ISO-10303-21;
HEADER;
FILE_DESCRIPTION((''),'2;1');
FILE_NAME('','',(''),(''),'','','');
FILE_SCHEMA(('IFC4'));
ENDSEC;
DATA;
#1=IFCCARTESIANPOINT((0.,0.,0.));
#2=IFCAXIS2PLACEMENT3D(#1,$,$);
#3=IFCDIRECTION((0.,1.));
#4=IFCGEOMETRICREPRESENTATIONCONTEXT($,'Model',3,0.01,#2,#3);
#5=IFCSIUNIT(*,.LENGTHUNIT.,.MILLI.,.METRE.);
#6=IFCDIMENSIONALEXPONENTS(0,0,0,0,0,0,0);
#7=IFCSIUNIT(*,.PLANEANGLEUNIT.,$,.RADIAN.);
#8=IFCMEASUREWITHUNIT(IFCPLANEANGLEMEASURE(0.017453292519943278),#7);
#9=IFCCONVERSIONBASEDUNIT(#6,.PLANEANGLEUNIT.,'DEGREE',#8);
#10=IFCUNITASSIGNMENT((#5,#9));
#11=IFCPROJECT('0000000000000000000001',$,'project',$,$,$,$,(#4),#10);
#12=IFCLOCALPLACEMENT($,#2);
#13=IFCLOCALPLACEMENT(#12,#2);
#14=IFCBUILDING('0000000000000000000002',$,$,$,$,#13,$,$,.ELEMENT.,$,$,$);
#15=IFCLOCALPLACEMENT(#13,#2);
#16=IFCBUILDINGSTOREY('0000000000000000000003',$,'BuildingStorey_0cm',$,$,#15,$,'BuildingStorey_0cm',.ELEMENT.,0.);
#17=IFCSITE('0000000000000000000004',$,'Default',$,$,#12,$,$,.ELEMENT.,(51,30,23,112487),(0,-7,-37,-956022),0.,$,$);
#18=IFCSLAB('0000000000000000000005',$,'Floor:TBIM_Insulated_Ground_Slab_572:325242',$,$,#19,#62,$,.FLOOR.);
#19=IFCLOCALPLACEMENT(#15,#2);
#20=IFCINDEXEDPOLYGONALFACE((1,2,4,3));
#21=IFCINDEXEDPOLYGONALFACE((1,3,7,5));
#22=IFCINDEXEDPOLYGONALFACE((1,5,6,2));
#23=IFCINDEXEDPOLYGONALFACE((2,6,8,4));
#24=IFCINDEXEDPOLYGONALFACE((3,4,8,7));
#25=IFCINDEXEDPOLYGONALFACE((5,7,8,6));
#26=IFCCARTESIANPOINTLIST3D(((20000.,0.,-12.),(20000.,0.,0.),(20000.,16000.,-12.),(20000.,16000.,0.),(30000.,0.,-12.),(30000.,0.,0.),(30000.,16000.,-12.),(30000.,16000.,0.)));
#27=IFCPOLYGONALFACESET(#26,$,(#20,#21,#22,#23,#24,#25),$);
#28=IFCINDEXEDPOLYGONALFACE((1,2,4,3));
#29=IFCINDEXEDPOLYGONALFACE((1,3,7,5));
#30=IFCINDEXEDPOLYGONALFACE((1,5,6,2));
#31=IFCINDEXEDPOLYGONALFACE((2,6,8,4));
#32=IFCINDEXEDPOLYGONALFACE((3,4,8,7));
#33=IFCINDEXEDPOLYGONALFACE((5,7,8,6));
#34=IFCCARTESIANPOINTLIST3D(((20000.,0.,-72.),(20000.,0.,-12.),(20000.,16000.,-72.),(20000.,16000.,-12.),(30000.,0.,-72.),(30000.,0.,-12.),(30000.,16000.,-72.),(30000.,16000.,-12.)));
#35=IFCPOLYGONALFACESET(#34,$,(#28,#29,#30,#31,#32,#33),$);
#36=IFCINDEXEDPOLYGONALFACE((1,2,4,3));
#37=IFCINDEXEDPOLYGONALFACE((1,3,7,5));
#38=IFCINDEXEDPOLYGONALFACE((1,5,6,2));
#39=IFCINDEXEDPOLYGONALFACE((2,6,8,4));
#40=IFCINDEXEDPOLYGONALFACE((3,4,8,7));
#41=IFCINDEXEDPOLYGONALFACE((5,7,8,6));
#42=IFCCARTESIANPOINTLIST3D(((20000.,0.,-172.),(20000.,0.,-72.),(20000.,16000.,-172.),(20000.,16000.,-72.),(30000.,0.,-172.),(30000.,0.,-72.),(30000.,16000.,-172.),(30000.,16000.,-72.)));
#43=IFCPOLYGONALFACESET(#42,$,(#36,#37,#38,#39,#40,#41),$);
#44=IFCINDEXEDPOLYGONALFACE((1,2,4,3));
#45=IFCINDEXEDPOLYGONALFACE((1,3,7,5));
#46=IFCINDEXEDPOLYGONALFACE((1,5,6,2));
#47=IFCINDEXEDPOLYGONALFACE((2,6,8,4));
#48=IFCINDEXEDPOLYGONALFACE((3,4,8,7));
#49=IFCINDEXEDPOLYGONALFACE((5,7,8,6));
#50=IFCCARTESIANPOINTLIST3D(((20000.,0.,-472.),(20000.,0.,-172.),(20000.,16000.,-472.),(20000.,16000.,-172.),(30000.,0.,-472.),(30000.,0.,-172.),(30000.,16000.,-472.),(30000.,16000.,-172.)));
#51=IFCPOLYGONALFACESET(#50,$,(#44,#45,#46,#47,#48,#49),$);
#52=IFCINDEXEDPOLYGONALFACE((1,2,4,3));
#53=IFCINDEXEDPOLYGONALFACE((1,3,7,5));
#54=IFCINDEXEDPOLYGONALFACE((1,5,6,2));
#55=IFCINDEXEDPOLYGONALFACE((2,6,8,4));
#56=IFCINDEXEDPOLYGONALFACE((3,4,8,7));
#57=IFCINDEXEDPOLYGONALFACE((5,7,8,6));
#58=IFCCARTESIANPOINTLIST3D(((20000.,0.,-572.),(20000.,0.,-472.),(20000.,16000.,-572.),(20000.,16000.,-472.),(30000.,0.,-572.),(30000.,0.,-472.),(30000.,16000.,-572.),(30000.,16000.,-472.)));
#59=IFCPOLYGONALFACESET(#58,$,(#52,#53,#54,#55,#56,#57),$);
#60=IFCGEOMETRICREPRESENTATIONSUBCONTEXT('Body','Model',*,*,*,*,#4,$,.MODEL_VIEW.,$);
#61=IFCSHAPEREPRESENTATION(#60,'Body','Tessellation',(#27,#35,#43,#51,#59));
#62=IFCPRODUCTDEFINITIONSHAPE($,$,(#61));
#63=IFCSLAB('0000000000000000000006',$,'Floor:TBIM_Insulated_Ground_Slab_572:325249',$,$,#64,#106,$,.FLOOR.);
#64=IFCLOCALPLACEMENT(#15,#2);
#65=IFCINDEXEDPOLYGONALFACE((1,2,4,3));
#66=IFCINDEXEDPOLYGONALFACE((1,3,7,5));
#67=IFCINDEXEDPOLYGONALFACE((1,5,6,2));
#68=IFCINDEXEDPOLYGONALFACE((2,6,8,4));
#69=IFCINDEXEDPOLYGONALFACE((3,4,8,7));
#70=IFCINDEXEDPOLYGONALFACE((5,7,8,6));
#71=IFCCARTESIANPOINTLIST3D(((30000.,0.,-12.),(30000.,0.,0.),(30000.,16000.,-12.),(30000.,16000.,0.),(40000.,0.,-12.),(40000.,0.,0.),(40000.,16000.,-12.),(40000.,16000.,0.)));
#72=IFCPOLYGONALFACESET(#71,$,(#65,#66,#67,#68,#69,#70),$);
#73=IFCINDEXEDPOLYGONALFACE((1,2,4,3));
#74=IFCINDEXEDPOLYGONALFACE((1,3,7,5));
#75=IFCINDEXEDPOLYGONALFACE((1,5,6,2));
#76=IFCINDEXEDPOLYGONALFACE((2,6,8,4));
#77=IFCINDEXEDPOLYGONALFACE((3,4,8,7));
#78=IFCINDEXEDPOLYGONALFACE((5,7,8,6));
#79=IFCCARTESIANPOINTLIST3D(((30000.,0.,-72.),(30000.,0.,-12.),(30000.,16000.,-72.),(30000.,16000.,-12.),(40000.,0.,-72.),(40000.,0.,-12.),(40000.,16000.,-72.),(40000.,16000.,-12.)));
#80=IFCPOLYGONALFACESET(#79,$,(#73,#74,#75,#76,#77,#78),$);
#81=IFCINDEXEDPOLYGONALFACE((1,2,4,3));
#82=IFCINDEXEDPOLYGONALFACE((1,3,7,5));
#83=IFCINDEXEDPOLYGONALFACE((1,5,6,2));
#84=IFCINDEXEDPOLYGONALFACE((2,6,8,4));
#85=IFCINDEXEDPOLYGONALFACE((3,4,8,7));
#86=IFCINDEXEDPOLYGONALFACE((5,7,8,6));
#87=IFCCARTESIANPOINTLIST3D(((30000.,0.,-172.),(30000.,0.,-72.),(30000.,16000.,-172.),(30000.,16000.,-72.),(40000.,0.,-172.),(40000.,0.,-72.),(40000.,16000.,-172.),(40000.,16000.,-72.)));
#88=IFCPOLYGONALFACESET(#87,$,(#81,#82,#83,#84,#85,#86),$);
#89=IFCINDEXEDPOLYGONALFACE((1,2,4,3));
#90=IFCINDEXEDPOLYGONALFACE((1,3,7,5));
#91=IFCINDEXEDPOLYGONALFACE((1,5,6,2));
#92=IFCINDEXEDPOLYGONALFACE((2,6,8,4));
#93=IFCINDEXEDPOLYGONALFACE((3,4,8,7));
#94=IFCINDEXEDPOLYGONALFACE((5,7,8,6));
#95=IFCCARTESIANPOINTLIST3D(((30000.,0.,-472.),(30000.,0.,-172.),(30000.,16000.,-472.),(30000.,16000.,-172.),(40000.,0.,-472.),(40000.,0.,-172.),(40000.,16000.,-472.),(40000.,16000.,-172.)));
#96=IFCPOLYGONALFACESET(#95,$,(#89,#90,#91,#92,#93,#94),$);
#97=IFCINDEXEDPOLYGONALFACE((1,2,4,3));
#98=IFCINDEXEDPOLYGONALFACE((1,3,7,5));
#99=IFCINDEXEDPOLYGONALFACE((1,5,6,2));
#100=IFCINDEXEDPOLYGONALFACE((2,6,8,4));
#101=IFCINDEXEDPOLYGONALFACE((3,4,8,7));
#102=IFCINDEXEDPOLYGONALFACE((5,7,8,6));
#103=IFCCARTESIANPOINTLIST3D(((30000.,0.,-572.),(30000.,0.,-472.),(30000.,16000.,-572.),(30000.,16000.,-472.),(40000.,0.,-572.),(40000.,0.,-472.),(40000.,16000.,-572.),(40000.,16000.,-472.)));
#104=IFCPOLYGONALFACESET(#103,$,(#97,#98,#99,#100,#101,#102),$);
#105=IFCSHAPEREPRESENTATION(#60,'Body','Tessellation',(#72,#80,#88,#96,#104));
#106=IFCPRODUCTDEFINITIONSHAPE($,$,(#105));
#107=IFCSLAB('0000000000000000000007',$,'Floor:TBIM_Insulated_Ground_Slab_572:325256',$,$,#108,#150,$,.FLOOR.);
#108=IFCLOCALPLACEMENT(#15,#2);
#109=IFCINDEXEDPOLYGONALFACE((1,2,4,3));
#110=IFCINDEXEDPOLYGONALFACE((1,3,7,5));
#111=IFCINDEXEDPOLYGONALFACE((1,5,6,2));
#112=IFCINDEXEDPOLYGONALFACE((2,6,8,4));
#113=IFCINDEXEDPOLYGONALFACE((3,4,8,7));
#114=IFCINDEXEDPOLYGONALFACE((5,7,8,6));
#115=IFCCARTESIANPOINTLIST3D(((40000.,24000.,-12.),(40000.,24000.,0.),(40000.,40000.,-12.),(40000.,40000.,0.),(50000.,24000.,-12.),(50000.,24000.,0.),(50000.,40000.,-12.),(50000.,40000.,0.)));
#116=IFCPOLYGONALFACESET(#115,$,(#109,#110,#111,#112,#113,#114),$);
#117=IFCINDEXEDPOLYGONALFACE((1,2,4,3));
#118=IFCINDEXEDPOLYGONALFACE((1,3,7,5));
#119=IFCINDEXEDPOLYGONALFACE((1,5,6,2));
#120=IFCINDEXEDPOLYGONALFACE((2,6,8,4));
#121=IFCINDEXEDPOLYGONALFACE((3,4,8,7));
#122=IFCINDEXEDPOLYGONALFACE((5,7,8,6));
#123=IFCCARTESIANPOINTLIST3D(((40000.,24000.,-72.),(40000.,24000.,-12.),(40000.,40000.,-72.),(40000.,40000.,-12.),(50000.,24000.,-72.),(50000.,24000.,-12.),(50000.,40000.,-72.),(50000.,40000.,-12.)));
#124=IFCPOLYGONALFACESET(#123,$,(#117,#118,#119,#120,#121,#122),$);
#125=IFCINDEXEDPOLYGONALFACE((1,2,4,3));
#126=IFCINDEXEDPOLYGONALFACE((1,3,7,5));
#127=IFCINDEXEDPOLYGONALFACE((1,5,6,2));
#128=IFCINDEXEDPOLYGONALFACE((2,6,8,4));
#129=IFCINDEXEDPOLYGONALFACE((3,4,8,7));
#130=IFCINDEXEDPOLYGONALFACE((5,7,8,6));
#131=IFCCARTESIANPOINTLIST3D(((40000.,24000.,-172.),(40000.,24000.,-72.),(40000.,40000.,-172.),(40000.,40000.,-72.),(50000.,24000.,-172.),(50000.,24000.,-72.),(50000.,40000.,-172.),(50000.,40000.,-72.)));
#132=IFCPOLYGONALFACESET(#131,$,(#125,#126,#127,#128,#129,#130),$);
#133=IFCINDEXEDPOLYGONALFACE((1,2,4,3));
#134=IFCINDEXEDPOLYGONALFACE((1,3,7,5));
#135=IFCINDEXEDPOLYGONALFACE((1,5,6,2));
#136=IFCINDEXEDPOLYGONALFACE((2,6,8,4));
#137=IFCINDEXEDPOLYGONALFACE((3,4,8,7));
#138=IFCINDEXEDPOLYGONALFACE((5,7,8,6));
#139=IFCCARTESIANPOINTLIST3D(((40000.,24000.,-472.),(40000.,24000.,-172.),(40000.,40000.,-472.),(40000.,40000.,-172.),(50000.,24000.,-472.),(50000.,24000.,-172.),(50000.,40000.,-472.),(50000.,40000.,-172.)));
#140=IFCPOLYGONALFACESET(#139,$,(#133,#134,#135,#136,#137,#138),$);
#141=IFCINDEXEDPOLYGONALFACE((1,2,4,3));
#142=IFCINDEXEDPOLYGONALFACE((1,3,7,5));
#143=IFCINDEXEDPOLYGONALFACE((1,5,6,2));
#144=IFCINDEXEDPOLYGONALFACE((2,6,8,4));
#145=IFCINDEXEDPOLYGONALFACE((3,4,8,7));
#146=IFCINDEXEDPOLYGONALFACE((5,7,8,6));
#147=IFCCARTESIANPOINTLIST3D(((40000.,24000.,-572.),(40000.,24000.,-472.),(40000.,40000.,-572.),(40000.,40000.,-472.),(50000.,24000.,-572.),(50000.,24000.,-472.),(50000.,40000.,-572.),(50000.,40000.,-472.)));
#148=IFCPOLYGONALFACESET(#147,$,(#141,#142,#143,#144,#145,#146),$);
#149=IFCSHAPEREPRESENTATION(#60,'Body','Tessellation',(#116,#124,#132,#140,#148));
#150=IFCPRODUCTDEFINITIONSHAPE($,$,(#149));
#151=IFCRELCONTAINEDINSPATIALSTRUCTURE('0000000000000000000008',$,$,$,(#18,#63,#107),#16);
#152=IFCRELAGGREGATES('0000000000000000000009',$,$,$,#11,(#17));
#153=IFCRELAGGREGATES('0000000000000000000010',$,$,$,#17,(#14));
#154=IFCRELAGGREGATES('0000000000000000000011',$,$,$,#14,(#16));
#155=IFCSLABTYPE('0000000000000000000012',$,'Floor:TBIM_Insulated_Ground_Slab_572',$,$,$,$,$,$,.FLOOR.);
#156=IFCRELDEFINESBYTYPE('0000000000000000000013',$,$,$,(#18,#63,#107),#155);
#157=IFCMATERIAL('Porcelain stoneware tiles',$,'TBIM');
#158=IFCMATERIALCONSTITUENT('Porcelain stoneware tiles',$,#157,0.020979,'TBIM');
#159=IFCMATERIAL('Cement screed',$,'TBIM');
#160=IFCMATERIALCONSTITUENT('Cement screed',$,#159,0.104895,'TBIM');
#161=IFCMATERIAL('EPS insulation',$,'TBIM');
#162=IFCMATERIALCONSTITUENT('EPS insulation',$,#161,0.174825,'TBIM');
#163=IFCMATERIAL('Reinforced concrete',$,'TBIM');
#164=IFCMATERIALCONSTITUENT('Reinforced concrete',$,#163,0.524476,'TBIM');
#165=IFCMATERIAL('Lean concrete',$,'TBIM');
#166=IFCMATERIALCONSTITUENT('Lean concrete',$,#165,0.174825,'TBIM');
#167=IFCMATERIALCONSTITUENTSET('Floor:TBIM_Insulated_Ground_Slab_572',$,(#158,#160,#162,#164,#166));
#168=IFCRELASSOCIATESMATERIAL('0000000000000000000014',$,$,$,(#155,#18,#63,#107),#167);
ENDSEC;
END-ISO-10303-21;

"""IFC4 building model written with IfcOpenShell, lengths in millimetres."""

from ifc_helpers import new_model, entity, si_unit, converted_unit, direction, frame, origin, place, context, subcontext, project, spatial, indexed_curve, outline, extrude, material, constituent, constituent_set, type_object, element, save


model = new_model("IFC4")

# Units and contexts
model_context = context("Model", 3, precision=0.01, world=origin(), true_north=direction((0.0, 1.0)))
body_context = subcontext(model_context, "Body", "Model", "MODEL_VIEW")
ifc_project = project(units=[si_unit("LENGTHUNIT", "METRE", prefix="MILLI"), converted_unit("PLANEANGLEUNIT", "DEGREE", entity("IfcPlaneAngleMeasure", 0.017453292519943278), si_unit("PLANEANGLEUNIT", "RADIAN"), dimensions=[0, 0, 0, 0, 0, 0, 0])], contexts=[model_context])

# Site, building, storey
site_placement = place(None, origin())
site = spatial("IfcSite", under=ifc_project, at=site_placement, Name="Default", CompositionType="ELEMENT", RefLatitude=(51, 30, 23, 112487), RefLongitude=(0, -7, -37, -956022), RefElevation=0.0)
building_placement = place(site_placement, origin())
building = spatial("IfcBuilding", under=site, at=building_placement, CompositionType="ELEMENT")
storey_placement = place(building_placement, origin())
storey = spatial("IfcBuildingStorey", under=building, at=storey_placement, Name="BuildingStorey_0cm", LongName="BuildingStorey_0cm", CompositionType="ELEMENT", Elevation=0.0)

# Slabs
ifc_material_1 = material(Name="Porcelain stoneware tiles", Category="TBIM")
ifc_constituent_1 = constituent(ifc_material_1, Name="Porcelain stoneware tiles", Category="TBIM", fraction=0.020979)
ifc_material_2 = material(Name="Cement screed", Category="TBIM")
ifc_constituent_2 = constituent(ifc_material_2, Name="Cement screed", Category="TBIM", fraction=0.104895)
ifc_material_3 = material(Name="EPS insulation", Category="TBIM")
ifc_constituent_3 = constituent(ifc_material_3, Name="EPS insulation", Category="TBIM", fraction=0.174825)
ifc_material_4 = material(Name="Reinforced concrete", Category="TBIM")
ifc_constituent_4 = constituent(ifc_material_4, Name="Reinforced concrete", Category="TBIM", fraction=0.524476)
ifc_material_5 = material(Name="Lean concrete", Category="TBIM")
ifc_constituent_5 = constituent(ifc_material_5, Name="Lean concrete", Category="TBIM", fraction=0.174825)
ifc_constituent_set_1 = constituent_set(constituents=[ifc_constituent_1, ifc_constituent_2, ifc_constituent_3, ifc_constituent_4, ifc_constituent_5], Name="Floor:TBIM_Insulated_Ground_Slab_572")
slab_type = type_object("IfcSlabType", Name="Floor:TBIM_Insulated_Ground_Slab_572", PredefinedType="FLOOR", material=ifc_constituent_set_1)
slab_1_placement = place(storey_placement, origin())
element("IfcSlab", 1, at=slab_1_placement, inside=storey, type_object=slab_type, material=ifc_constituent_set_1, Name="Floor:TBIM_Insulated_Ground_Slab_572:325242", PredefinedType="FLOOR", context=body_context, shape_type="SweptSolid", body=[
    extrude(outline(indexed_curve([(-5000.0, -8000.0), (5000.0, -8000.0), (5000.0, 8000.0), (-5000.0, 8000.0), (-5000.0, -8000.0)], self_intersect=False)), frame((25000.0, 8000.0, -12.0), z_axis=(0.0, 0.0, 1.0), x_axis=(-1.0, 0.0, 0.0)), (0.0, 0.0, 1.0), 12.0),
    extrude(outline(indexed_curve([(-5000.0, -8000.0), (5000.0, -8000.0), (5000.0, 8000.0), (-5000.0, 8000.0), (-5000.0, -8000.0)], self_intersect=False)), frame((25000.0, 8000.0, -72.0), z_axis=(0.0, 0.0, 1.0), x_axis=(-1.0, 0.0, 0.0)), (0.0, 0.0, 1.0), 60.0),
    extrude(outline(indexed_curve([(-5000.0, -8000.0), (5000.0, -8000.0), (5000.0, 8000.0), (-5000.0, 8000.0), (-5000.0, -8000.0)], self_intersect=False)), frame((25000.0, 8000.0, -172.0), z_axis=(0.0, 0.0, 1.0), x_axis=(-1.0, 0.0, 0.0)), (0.0, 0.0, 1.0), 100.0),
    extrude(outline(indexed_curve([(-5000.0, -8000.0), (5000.0, -8000.0), (5000.0, 8000.0), (-5000.0, 8000.0), (-5000.0, -8000.0)], self_intersect=False)), frame((25000.0, 8000.0, -472.0), z_axis=(0.0, 0.0, 1.0), x_axis=(-1.0, 0.0, 0.0)), (0.0, 0.0, 1.0), 300.0),
    extrude(outline(indexed_curve([(-5000.0, -8000.0), (5000.0, -8000.0), (5000.0, 8000.0), (-5000.0, 8000.0), (-5000.0, -8000.0)], self_intersect=False)), frame((25000.0, 8000.0, -572.0), z_axis=(0.0, 0.0, 1.0), x_axis=(-1.0, 0.0, 0.0)), (0.0, 0.0, 1.0), 100.0),
])
slab_2_placement = place(storey_placement, origin())
element("IfcSlab", 2, at=slab_2_placement, inside=storey, type_object=slab_type, material=ifc_constituent_set_1, Name="Floor:TBIM_Insulated_Ground_Slab_572:325249", PredefinedType="FLOOR", context=body_context, shape_type="SweptSolid", body=[
    extrude(outline(indexed_curve([(-5000.0, -8000.0), (5000.0, -8000.0), (5000.0, 8000.0), (-5000.0, 8000.0), (-5000.0, -8000.0)], self_intersect=False)), frame((35000.0, 8000.0, -12.0), z_axis=(0.0, 0.0, 1.0), x_axis=(-1.0, 0.0, 0.0)), (0.0, 0.0, 1.0), 12.0),
    extrude(outline(indexed_curve([(-5000.0, -8000.0), (5000.0, -8000.0), (5000.0, 8000.0), (-5000.0, 8000.0), (-5000.0, -8000.0)], self_intersect=False)), frame((35000.0, 8000.0, -72.0), z_axis=(0.0, 0.0, 1.0), x_axis=(-1.0, 0.0, 0.0)), (0.0, 0.0, 1.0), 60.0),
    extrude(outline(indexed_curve([(-5000.0, -8000.0), (5000.0, -8000.0), (5000.0, 8000.0), (-5000.0, 8000.0), (-5000.0, -8000.0)], self_intersect=False)), frame((35000.0, 8000.0, -172.0), z_axis=(0.0, 0.0, 1.0), x_axis=(-1.0, 0.0, 0.0)), (0.0, 0.0, 1.0), 100.0),
    extrude(outline(indexed_curve([(-5000.0, -8000.0), (5000.0, -8000.0), (5000.0, 8000.0), (-5000.0, 8000.0), (-5000.0, -8000.0)], self_intersect=False)), frame((35000.0, 8000.0, -472.0), z_axis=(0.0, 0.0, 1.0), x_axis=(-1.0, 0.0, 0.0)), (0.0, 0.0, 1.0), 300.0),
    extrude(outline(indexed_curve([(-5000.0, -8000.0), (5000.0, -8000.0), (5000.0, 8000.0), (-5000.0, 8000.0), (-5000.0, -8000.0)], self_intersect=False)), frame((35000.0, 8000.0, -572.0), z_axis=(0.0, 0.0, 1.0), x_axis=(-1.0, 0.0, 0.0)), (0.0, 0.0, 1.0), 100.0),
])
slab_3_placement = place(storey_placement, origin())
element("IfcSlab", 3, at=slab_3_placement, inside=storey, type_object=slab_type, material=ifc_constituent_set_1, Name="Floor:TBIM_Insulated_Ground_Slab_572:325256", PredefinedType="FLOOR", context=body_context, shape_type="SweptSolid", body=[
    extrude(outline(indexed_curve([(-5000.0, -8000.0), (5000.0, -8000.0), (5000.0, 8000.0), (-5000.0, 8000.0), (-5000.0, -8000.0)], self_intersect=False)), frame((45000.0, 32000.0, -12.0), z_axis=(0.0, 0.0, 1.0), x_axis=(-1.0, 0.0, 0.0)), (0.0, 0.0, 1.0), 12.0),
    extrude(outline(indexed_curve([(-5000.0, -8000.0), (5000.0, -8000.0), (5000.0, 8000.0), (-5000.0, 8000.0), (-5000.0, -8000.0)], self_intersect=False)), frame((45000.0, 32000.0, -72.0), z_axis=(0.0, 0.0, 1.0), x_axis=(-1.0, 0.0, 0.0)), (0.0, 0.0, 1.0), 60.0),
    extrude(outline(indexed_curve([(-5000.0, -8000.0), (5000.0, -8000.0), (5000.0, 8000.0), (-5000.0, 8000.0), (-5000.0, -8000.0)], self_intersect=False)), frame((45000.0, 32000.0, -172.0), z_axis=(0.0, 0.0, 1.0), x_axis=(-1.0, 0.0, 0.0)), (0.0, 0.0, 1.0), 100.0),
    extrude(outline(indexed_curve([(-5000.0, -8000.0), (5000.0, -8000.0), (5000.0, 8000.0), (-5000.0, 8000.0), (-5000.0, -8000.0)], self_intersect=False)), frame((45000.0, 32000.0, -472.0), z_axis=(0.0, 0.0, 1.0), x_axis=(-1.0, 0.0, 0.0)), (0.0, 0.0, 1.0), 300.0),
    extrude(outline(indexed_curve([(-5000.0, -8000.0), (5000.0, -8000.0), (5000.0, 8000.0), (-5000.0, 8000.0), (-5000.0, -8000.0)], self_intersect=False)), frame((45000.0, 32000.0, -572.0), z_axis=(0.0, 0.0, 1.0), x_axis=(-1.0, 0.0, 0.0)), (0.0, 0.0, 1.0), 100.0),
])

save(model, "model.ifc")
